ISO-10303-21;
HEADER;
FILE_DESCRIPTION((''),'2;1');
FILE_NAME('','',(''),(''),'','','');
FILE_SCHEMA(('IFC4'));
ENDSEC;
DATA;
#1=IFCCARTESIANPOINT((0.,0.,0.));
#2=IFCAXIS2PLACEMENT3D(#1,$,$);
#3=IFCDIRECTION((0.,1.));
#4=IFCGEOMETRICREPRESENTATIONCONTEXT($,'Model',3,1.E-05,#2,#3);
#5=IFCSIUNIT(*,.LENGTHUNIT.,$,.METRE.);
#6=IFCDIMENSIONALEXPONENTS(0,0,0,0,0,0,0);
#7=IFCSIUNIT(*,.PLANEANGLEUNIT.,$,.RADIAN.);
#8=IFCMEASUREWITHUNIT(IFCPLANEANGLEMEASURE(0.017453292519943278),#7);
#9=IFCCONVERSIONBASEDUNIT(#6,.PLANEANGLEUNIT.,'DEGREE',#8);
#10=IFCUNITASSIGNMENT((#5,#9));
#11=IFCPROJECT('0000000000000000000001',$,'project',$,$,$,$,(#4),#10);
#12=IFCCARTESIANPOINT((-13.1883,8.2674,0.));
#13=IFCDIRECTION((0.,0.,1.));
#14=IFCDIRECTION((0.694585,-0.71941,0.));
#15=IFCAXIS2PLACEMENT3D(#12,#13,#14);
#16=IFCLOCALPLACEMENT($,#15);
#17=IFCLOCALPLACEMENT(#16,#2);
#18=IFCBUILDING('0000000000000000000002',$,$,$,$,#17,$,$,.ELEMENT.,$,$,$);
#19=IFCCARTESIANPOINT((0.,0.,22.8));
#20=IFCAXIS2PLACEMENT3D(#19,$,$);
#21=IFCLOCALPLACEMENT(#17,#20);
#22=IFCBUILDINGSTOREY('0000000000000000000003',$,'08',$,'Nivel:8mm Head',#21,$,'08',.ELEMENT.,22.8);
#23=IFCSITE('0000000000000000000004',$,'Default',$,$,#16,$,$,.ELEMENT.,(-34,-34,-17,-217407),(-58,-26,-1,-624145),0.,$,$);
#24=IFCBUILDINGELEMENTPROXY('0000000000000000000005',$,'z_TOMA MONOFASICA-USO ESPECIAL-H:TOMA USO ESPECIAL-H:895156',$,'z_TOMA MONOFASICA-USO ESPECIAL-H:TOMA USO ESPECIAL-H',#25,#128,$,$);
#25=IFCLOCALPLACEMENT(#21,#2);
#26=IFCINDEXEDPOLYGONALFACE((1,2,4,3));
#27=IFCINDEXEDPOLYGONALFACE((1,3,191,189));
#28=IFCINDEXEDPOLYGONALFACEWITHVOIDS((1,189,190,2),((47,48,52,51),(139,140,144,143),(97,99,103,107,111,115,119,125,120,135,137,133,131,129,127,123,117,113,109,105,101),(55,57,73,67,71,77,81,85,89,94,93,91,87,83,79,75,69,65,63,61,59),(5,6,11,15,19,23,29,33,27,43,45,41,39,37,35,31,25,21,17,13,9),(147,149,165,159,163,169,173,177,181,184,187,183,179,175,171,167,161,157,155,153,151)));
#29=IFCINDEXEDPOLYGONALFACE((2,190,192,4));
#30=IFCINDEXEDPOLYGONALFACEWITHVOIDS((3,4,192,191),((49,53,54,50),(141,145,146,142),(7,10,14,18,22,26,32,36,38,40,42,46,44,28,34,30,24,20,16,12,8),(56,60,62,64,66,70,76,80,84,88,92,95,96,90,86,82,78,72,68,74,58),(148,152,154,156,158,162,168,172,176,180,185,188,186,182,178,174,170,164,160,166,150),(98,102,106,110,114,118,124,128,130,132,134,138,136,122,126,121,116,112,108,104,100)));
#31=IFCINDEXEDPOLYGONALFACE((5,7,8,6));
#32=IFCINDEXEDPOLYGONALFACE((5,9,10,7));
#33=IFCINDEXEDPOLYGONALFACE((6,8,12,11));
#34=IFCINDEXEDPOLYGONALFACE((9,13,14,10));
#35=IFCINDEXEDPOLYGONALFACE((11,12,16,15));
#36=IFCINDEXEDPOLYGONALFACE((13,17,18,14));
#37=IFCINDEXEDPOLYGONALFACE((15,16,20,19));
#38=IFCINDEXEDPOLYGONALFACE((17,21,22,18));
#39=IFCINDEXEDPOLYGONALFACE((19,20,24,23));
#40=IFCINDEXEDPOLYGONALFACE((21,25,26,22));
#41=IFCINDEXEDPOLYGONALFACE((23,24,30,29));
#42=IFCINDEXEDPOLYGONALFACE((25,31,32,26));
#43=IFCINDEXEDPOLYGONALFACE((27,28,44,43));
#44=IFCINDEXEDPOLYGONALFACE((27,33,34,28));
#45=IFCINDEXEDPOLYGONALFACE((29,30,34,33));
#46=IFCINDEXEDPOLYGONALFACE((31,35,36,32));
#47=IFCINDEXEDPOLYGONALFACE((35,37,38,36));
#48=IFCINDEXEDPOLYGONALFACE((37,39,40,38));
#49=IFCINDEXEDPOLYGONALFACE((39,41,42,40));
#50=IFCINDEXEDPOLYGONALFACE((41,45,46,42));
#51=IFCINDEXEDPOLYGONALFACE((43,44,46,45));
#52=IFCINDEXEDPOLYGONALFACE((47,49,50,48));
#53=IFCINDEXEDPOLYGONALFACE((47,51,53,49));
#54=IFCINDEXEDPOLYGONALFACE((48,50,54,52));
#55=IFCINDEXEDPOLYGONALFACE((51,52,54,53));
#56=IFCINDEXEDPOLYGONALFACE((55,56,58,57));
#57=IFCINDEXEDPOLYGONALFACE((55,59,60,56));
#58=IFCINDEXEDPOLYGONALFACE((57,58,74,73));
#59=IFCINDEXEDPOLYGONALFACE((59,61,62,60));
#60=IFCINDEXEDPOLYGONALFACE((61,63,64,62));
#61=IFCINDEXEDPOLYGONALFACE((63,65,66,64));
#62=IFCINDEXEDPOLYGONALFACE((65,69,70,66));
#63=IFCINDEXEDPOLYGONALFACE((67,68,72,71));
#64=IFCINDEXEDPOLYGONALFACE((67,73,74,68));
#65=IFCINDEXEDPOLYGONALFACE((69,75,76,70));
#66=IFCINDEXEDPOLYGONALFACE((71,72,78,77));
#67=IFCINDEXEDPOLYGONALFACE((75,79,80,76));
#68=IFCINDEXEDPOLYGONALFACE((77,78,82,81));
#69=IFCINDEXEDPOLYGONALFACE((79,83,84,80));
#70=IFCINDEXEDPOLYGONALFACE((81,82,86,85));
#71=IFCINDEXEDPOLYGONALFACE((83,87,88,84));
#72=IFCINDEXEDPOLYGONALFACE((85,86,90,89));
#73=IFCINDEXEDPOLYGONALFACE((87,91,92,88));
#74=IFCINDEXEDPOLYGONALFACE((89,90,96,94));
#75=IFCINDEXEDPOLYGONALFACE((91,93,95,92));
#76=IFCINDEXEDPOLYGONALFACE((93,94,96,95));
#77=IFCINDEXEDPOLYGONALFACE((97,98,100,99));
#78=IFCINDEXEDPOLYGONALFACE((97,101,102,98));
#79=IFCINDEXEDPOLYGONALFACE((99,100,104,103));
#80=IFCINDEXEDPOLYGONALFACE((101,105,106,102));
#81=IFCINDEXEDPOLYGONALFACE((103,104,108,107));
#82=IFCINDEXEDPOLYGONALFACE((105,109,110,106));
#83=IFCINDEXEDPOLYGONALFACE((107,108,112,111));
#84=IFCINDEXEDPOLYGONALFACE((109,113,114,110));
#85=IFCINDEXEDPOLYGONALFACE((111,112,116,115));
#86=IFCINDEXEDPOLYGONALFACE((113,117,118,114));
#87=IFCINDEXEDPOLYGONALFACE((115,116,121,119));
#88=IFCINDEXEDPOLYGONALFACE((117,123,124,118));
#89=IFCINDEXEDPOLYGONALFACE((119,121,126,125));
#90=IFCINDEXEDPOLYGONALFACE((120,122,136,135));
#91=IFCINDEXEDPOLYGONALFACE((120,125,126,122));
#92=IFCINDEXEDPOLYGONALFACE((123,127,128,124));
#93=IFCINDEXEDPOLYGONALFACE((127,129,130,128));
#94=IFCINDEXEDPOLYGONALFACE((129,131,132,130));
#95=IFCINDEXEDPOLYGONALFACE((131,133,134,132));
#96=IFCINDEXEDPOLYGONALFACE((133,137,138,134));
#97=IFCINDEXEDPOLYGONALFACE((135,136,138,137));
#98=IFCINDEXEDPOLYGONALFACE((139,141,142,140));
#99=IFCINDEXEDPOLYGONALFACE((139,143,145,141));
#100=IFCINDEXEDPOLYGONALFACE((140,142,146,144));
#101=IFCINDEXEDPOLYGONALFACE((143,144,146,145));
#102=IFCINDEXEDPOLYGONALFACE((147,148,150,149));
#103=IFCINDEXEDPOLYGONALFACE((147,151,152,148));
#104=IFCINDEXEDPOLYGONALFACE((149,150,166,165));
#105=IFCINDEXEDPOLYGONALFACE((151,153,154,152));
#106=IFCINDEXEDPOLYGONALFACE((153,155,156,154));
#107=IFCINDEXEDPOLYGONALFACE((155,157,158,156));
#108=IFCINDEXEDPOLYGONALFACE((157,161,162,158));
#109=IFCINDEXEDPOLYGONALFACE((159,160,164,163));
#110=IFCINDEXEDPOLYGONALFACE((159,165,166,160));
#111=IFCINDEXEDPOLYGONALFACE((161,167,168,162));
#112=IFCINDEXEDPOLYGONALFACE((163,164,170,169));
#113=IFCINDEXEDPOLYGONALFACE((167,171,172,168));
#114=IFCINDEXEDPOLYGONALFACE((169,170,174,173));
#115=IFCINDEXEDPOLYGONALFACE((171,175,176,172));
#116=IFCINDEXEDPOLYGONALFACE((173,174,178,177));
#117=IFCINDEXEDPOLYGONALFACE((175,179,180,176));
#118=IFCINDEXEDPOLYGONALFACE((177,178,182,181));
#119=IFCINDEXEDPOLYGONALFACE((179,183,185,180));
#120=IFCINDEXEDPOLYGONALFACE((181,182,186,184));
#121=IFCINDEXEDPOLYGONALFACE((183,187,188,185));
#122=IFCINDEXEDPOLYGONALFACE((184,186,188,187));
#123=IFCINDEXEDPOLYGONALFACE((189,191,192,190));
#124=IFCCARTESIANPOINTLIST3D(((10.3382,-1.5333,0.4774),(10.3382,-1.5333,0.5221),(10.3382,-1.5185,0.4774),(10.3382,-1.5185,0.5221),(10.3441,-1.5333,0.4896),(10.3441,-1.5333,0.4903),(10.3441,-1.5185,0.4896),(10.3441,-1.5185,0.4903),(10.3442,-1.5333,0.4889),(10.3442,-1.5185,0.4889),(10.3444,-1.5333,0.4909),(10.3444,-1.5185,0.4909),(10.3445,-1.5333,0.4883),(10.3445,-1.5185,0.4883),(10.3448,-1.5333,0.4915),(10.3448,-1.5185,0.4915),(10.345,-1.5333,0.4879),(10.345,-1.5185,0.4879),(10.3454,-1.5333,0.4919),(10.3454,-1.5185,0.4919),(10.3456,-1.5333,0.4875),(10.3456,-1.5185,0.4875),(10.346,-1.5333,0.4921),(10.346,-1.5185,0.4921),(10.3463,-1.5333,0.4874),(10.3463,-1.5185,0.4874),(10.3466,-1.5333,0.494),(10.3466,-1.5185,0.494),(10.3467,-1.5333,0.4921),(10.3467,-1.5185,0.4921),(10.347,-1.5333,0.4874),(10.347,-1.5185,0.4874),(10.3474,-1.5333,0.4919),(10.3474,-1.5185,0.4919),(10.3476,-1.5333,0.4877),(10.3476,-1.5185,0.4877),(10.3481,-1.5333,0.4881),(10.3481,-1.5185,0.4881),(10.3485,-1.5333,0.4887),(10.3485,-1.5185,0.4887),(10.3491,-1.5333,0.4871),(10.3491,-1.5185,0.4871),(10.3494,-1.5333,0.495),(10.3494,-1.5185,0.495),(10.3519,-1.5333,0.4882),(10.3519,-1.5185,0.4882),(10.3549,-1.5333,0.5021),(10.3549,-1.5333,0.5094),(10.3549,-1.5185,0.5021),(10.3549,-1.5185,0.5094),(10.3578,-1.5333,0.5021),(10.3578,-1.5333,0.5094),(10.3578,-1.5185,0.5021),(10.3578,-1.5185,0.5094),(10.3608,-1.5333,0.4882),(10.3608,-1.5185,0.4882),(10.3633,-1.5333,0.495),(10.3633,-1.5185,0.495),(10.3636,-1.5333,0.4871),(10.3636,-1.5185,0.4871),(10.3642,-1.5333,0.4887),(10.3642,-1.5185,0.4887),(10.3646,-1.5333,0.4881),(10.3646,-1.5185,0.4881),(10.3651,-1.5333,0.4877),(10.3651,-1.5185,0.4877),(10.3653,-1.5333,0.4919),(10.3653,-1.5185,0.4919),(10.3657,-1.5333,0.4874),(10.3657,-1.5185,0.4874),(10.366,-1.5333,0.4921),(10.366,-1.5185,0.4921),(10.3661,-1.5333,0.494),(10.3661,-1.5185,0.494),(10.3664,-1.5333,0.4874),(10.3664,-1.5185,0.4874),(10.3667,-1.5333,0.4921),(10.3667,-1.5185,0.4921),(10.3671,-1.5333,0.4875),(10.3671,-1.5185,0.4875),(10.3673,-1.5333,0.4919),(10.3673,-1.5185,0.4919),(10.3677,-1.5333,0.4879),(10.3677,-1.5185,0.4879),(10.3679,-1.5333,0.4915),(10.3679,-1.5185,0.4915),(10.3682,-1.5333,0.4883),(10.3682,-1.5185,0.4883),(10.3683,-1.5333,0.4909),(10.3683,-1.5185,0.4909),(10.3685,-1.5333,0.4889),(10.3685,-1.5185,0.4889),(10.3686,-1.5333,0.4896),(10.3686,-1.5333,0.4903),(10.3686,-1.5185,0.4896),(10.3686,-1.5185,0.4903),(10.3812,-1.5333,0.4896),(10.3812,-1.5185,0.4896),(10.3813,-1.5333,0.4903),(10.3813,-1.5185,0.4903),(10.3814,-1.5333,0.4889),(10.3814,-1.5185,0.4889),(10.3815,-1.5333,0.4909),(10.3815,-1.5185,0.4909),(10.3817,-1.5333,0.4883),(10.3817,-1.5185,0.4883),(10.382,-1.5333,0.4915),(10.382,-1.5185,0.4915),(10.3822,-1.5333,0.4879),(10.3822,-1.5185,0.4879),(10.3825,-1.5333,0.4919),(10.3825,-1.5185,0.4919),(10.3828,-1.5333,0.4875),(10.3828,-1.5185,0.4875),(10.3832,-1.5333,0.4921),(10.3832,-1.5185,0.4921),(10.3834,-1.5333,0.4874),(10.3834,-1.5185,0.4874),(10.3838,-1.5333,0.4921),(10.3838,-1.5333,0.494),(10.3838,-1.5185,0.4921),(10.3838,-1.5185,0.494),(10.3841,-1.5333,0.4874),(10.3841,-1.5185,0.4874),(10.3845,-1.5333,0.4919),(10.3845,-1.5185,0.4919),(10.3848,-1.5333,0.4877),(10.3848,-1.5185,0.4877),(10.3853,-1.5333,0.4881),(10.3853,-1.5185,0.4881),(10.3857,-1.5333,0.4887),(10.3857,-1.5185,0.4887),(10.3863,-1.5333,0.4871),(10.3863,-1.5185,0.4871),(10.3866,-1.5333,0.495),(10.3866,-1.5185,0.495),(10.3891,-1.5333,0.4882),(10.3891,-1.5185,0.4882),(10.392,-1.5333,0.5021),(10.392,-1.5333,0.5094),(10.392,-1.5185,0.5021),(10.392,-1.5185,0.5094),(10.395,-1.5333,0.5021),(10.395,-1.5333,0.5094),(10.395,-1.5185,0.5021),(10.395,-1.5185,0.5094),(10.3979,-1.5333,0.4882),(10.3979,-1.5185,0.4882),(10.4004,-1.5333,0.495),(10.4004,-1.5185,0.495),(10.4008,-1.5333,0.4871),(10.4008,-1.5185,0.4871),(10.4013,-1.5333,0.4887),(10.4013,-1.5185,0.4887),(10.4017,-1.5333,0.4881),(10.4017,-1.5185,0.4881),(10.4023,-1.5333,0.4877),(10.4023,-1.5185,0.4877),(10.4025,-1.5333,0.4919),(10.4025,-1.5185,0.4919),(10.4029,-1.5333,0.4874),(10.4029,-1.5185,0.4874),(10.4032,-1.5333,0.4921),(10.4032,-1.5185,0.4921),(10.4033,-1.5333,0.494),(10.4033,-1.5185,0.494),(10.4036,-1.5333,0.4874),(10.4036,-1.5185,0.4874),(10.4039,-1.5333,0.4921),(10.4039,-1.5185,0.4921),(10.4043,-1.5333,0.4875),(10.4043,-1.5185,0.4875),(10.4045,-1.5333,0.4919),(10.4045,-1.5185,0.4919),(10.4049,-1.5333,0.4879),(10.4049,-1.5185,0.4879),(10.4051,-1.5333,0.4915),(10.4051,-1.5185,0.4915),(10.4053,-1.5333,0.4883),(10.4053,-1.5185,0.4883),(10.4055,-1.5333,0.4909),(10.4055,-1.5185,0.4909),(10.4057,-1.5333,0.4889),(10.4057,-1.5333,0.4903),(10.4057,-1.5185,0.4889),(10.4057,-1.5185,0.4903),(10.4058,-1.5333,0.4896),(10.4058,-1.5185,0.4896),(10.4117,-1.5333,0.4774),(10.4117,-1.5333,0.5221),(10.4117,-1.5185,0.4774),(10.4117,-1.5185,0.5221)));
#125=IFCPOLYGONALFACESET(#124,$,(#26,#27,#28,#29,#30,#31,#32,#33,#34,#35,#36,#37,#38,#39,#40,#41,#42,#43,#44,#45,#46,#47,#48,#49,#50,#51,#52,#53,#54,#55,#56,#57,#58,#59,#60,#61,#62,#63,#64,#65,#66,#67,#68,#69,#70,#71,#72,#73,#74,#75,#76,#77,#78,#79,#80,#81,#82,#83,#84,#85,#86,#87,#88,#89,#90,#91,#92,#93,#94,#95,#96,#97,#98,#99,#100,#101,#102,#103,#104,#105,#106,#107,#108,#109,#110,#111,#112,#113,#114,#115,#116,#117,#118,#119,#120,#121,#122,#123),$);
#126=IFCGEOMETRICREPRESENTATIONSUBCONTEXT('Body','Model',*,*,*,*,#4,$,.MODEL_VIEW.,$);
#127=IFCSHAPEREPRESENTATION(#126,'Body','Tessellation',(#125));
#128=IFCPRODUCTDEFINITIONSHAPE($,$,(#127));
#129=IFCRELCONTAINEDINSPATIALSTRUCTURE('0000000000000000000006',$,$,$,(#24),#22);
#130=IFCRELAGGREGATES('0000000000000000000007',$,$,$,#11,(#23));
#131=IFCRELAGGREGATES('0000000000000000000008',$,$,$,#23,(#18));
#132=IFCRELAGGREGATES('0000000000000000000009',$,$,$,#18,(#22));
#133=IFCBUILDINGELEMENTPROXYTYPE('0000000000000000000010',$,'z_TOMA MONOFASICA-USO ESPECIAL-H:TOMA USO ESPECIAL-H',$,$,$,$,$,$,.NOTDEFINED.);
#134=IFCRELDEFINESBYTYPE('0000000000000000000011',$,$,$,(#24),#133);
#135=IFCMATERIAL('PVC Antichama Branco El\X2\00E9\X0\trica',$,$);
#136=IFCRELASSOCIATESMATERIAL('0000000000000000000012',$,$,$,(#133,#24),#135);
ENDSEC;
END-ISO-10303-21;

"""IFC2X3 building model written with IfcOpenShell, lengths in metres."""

from ifc_helpers import new_model, entity, si_unit, converted_unit, direction, frame, frame_2d, origin, place, context, subcontext, project, spatial, polyline, circle_curve, parameter, trimmed, segment, composite_curve, outline, extrude, source, transform, mapped, material, type_object, type_shapes, element, save


model = new_model("IFC2X3")

# Units and contexts
model_context = context("Model", 3, precision=1e-05, world=origin(), true_north=direction((0.0, 1.0)))
body_context = subcontext(model_context, "Body", "Model", "MODEL_VIEW")
ifc_project = project(units=[si_unit("LENGTHUNIT", "METRE"), converted_unit("PLANEANGLEUNIT", "DEGREE", entity("IfcPlaneAngleMeasure", 0.017453292519943278), si_unit("PLANEANGLEUNIT", "RADIAN"), dimensions=[0, 0, 0, 0, 0, 0, 0])], contexts=[model_context])

# Site, building, storey
site_placement = place(None, frame((-13.1883, 8.2674, 0.0), z_axis=(0.0, 0.0, 1.0), x_axis=(0.694585, -0.71941, 0.0)))
site = spatial("IfcSite", under=ifc_project, at=site_placement, Name="Default", CompositionType="ELEMENT", RefLatitude=(-34, -34, -17, -217407), RefLongitude=(-58, -26, -1, -624145), RefElevation=0.0)
building_placement = place(site_placement, origin())
building = spatial("IfcBuilding", under=site, at=building_placement, CompositionType="ELEMENT")
storey_placement = place(building_placement, frame((0.0, 0.0, 22.8)))
storey = spatial("IfcBuildingStorey", under=building, at=storey_placement, Name="08", ObjectType="Nivel:8mm Head", LongName="08", CompositionType="ELEMENT", Elevation=22.8)

# Building element proxy
ifc_material_1 = material(Name="PVC Antichama Branco Elétrica")
building_element_proxy_type_1 = type_object("IfcBuildingElementProxyType", Name="z_TOMA MONOFASICA-USO ESPECIAL-H:TOMA USO ESPECIAL-H", PredefinedType="NOTDEFINED", material=ifc_material_1)
shared_shape_1 = source(origin(), body_context, "Body", "SweptSolid", [
    extrude(outline(polyline([(-0.0368, -0.0223), (0.0368, -0.0223), (0.0368, 0.0223), (-0.0368, 0.0223), (-0.0368, -0.0223)]), holes=[composite_curve([segment(polyline([(0.0141, 0.0115), (0.0116, 0.0047)]), True, "CONTINUOUS"), segment(polyline([(0.0116, 0.0047), (0.0088, 0.0057)]), True, "CONTINUOUS"), segment(polyline([(0.0088, 0.0057), (0.0096, 0.0078)]), True, "CONTINUOUS"), segment(trimmed(circle_curve(frame_2d((0.0087, 0.0099), x_axis=(1.0, 0.0)), 0.0024), [parameter(27.118901)], [parameter(292.881099)], True, "PARAMETER"), False, "CONTINUOUS"), segment(polyline([(0.0108, 0.011), (0.0113, 0.0126)]), True, "CONTINUOUS"), segment(polyline([(0.0113, 0.0126), (0.0141, 0.0115)]), True, "CONTINUOUS")], self_intersect=False), composite_curve([segment(polyline([(0.0255, 0.0047), (0.023, 0.0115)]), True, "CONTINUOUS"), segment(polyline([(0.023, 0.0115), (0.0258, 0.0126)]), True, "CONTINUOUS"), segment(polyline([(0.0258, 0.0126), (0.0264, 0.011)]), True, "CONTINUOUS"), segment(trimmed(circle_curve(frame_2d((0.0285, 0.0099), x_axis=(1.0, 0.0)), 0.0024), [parameter(247.118901)], [parameter(152.881099)], True, "PARAMETER"), False, "CONTINUOUS"), segment(polyline([(0.0276, 0.0078), (0.0283, 0.0057)]), True, "CONTINUOUS"), segment(polyline([(0.0283, 0.0057), (0.0255, 0.0047)]), True, "CONTINUOUS")], self_intersect=False), polyline([(0.0201, -0.0024), (0.0201, -0.0097), (0.0171, -0.0097), (0.0171, -0.0024), (0.0201, -0.0024)]), composite_curve([segment(polyline([(-0.0141, 0.0115), (-0.0113, 0.0126)]), True, "CONTINUOUS"), segment(polyline([(-0.0113, 0.0126), (-0.0108, 0.011)]), True, "CONTINUOUS"), segment(trimmed(circle_curve(frame_2d((-0.0087, 0.0099), x_axis=(1.0, 0.0)), 0.0024), [parameter(247.118901)], [parameter(152.881099)], True, "PARAMETER"), False, "CONTINUOUS"), segment(polyline([(-0.0096, 0.0078), (-0.0088, 0.0057)]), True, "CONTINUOUS"), segment(polyline([(-0.0088, 0.0057), (-0.0116, 0.0047)]), True, "CONTINUOUS"), segment(polyline([(-0.0116, 0.0047), (-0.0141, 0.0115)]), True, "CONTINUOUS")], self_intersect=False), composite_curve([segment(polyline([(-0.0255, 0.0047), (-0.0283, 0.0057)]), True, "CONTINUOUS"), segment(polyline([(-0.0283, 0.0057), (-0.0276, 0.0078)]), True, "CONTINUOUS"), segment(trimmed(circle_curve(frame_2d((-0.0285, 0.0099), x_axis=(1.0, 0.0)), 0.0024), [parameter(27.118901)], [parameter(292.881099)], True, "PARAMETER"), False, "CONTINUOUS"), segment(polyline([(-0.0264, 0.011), (-0.0258, 0.0126)]), True, "CONTINUOUS"), segment(polyline([(-0.0258, 0.0126), (-0.023, 0.0115)]), True, "CONTINUOUS"), segment(polyline([(-0.023, 0.0115), (-0.0255, 0.0047)]), True, "CONTINUOUS")], self_intersect=False), polyline([(-0.0201, -0.0024), (-0.0171, -0.0024), (-0.0171, -0.0097), (-0.0201, -0.0097), (-0.0201, -0.0024)])]), frame((0.0, -0.005, 0.0223), z_axis=(0.0, 1.0, 0.0), x_axis=(1.0, 0.0, 0.0)), (0.0, 0.0, 1.0), 0.0148),
])
type_shapes(building_element_proxy_type_1, [shared_shape_1])
proxy_1_placement = place(storey_placement, frame((10.3749, -1.5283, 0.4774)))
element("IfcBuildingElementProxy", 1, at=proxy_1_placement, inside=storey, type_object=building_element_proxy_type_1, material=ifc_material_1, Name="z_TOMA MONOFASICA-USO ESPECIAL-H:TOMA USO ESPECIAL-H:895156", ObjectType="z_TOMA MONOFASICA-USO ESPECIAL-H:TOMA USO ESPECIAL-H", context=body_context, shape_type="MappedRepresentation", body=[
    mapped(shared_shape_1, transform((0.0, 0.0, 0.0), scale=1.0)),
])

save(model, "model.ifc")
